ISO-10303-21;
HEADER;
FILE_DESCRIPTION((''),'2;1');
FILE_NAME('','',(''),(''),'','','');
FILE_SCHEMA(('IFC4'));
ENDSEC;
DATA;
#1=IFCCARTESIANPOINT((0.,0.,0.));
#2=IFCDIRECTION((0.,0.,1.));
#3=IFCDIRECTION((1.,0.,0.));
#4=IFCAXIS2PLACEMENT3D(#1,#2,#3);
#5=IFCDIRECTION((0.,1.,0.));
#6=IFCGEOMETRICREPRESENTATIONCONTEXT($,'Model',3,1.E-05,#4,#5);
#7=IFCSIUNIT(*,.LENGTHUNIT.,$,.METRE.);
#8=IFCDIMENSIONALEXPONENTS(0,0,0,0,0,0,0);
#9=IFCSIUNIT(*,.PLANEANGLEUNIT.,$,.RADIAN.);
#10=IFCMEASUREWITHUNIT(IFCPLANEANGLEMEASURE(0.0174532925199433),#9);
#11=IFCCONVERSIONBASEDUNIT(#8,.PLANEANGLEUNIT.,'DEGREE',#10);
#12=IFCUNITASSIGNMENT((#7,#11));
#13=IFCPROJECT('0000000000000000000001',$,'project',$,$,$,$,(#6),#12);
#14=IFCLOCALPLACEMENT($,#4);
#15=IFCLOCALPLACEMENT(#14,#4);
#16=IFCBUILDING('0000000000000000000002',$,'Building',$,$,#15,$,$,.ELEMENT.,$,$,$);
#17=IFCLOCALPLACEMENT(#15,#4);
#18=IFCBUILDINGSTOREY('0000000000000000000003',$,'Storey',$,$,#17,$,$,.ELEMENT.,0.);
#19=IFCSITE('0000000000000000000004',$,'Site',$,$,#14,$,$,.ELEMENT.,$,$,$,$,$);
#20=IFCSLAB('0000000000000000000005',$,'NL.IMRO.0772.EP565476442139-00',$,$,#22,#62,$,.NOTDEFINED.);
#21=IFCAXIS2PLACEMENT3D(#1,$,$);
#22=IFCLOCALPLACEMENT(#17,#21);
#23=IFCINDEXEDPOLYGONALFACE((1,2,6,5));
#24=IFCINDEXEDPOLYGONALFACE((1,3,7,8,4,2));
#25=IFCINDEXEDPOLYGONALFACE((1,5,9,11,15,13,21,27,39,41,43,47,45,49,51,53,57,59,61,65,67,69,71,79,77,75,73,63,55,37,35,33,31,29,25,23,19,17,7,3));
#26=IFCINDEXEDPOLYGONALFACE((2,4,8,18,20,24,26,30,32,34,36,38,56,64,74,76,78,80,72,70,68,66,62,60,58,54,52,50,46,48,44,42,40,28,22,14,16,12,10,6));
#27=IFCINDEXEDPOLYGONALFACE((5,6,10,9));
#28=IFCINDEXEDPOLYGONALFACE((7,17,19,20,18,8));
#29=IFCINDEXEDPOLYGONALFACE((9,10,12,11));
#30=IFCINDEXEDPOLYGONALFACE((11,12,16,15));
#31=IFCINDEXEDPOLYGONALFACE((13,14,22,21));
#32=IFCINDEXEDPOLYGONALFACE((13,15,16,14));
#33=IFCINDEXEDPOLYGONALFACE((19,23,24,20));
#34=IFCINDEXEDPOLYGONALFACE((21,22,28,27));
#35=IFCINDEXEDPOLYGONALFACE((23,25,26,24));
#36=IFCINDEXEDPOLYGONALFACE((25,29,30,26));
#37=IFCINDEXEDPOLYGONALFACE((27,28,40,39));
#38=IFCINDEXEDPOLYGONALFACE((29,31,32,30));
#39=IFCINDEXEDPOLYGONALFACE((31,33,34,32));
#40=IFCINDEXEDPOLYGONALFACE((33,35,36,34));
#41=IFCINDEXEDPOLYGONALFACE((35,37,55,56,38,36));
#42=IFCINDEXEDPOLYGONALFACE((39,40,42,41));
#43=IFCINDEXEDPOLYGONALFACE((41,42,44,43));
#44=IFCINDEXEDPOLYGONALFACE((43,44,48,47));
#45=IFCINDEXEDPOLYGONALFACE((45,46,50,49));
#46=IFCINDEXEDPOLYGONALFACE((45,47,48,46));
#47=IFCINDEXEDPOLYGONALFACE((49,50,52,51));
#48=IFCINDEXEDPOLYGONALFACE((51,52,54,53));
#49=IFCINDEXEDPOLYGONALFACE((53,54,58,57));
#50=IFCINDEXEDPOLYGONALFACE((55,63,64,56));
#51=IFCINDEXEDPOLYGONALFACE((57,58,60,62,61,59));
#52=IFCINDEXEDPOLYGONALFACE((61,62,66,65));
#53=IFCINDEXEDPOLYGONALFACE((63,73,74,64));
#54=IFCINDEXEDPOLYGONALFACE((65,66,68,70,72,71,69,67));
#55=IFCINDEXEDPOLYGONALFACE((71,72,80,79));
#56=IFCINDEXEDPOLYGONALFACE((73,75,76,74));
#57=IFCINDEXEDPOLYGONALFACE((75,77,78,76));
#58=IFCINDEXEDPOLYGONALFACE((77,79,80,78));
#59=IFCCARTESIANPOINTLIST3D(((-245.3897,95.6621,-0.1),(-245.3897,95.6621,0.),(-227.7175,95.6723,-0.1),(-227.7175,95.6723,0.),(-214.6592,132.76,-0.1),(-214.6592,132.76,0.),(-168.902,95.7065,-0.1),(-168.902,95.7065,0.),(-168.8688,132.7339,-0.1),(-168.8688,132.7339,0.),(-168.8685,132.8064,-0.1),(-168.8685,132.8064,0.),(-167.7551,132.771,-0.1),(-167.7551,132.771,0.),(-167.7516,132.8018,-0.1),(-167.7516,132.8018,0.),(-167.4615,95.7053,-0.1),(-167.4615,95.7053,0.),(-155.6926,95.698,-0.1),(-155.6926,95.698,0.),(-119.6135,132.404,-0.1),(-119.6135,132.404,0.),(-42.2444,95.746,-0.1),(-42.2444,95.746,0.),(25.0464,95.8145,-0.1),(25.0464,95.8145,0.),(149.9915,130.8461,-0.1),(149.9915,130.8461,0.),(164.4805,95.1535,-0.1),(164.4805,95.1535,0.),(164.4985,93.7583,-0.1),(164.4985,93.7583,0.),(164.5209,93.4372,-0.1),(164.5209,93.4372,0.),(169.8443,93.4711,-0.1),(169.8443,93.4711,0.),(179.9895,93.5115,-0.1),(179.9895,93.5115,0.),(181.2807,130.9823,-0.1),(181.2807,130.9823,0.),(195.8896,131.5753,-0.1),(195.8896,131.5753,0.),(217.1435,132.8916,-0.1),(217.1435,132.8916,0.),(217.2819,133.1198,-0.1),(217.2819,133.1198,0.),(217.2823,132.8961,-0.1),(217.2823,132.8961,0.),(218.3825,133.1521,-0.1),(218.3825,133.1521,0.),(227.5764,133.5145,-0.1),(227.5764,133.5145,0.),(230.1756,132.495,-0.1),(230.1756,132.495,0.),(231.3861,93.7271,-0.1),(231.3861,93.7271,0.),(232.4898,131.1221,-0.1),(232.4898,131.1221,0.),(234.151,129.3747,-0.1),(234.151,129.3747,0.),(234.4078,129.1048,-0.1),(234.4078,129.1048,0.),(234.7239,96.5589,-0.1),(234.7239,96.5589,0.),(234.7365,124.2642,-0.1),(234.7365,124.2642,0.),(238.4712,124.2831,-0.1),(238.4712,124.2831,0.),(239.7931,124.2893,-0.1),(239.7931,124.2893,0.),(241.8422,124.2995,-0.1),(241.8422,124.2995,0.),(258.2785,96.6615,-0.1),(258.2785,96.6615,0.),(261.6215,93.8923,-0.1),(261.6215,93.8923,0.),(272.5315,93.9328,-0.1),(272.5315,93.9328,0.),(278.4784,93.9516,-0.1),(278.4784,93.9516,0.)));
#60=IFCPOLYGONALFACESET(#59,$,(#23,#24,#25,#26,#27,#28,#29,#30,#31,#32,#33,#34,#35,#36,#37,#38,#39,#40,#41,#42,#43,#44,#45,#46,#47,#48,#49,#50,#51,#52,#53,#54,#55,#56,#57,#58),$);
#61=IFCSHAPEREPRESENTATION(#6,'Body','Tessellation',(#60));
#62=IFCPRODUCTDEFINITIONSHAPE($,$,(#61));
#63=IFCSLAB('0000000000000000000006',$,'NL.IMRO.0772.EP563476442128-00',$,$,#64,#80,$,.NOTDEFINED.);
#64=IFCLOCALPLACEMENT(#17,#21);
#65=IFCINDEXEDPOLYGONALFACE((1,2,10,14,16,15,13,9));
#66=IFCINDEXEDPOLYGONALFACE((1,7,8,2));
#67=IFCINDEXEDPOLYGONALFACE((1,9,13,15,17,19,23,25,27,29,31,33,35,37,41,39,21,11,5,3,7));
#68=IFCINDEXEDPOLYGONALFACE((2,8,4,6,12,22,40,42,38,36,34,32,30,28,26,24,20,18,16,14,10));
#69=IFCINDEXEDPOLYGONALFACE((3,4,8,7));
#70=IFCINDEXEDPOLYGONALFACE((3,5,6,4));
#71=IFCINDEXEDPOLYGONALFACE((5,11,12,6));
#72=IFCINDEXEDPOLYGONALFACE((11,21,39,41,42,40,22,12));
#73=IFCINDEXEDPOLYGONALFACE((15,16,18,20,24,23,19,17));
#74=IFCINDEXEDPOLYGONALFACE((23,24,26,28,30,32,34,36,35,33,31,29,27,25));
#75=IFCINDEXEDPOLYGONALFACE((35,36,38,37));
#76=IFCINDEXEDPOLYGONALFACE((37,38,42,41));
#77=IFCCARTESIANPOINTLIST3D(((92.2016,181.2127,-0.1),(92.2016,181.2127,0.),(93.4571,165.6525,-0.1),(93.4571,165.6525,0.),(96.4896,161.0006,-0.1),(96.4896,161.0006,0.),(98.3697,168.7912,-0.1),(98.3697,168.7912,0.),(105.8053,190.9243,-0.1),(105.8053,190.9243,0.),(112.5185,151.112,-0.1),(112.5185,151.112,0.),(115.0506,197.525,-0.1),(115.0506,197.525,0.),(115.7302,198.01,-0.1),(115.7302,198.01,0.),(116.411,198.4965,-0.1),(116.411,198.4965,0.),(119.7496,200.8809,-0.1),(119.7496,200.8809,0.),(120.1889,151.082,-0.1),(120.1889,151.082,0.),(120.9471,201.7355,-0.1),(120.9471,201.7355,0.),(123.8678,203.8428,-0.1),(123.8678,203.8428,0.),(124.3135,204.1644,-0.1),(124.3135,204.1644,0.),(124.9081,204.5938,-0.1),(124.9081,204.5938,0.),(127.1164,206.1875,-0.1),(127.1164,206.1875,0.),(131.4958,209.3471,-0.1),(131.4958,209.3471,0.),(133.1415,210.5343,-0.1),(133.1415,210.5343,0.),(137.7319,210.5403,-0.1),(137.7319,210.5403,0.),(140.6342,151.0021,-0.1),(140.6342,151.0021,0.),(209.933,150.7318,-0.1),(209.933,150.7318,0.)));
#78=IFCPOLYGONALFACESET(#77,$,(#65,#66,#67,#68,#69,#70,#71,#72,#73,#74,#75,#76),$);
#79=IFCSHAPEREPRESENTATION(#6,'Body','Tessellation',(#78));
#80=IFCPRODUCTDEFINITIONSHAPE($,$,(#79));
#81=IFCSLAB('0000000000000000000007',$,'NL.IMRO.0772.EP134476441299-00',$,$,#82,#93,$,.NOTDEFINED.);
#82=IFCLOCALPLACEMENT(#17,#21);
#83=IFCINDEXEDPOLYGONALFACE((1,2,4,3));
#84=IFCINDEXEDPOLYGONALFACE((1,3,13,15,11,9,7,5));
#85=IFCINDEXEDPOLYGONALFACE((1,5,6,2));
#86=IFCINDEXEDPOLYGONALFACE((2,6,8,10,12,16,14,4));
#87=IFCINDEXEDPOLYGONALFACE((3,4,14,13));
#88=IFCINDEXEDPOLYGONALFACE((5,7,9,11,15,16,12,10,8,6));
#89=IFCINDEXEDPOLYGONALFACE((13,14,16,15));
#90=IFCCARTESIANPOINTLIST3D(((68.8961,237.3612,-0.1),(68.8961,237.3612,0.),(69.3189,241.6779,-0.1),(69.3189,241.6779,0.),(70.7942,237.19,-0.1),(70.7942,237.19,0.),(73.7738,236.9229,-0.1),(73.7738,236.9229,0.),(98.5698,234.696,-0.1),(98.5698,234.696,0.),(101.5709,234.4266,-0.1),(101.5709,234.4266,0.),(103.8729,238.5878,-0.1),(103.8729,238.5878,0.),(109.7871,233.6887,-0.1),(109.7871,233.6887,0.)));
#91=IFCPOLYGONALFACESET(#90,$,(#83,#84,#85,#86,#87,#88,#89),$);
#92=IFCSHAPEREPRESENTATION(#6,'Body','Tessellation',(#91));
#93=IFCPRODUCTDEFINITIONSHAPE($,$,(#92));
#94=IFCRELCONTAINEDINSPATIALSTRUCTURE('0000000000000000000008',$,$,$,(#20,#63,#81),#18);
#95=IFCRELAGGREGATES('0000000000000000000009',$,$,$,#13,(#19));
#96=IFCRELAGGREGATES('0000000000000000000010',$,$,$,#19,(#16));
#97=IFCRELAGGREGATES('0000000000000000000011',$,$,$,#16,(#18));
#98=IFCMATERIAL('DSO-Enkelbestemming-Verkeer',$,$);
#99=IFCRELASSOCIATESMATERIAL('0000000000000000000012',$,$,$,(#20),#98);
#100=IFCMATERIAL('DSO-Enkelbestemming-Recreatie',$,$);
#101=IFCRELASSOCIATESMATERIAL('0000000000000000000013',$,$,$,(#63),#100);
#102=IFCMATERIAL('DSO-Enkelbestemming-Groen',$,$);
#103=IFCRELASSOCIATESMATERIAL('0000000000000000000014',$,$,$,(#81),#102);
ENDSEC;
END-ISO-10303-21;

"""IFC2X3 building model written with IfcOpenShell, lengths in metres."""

from ifc_helpers import new_model, entity, si_unit, converted_unit, direction, frame, origin_with_axes, place, context, project, spatial, polyline, outline, extrude, material, element, save


model = new_model("IFC2X3")

# Units and contexts
model_context = context("Model", 3, precision=1e-05, world=origin_with_axes(), true_north=direction((0.0, 1.0, 0.0)))
ifc_project = project(units=[si_unit("LENGTHUNIT", "METRE"), converted_unit("PLANEANGLEUNIT", "DEGREE", entity("IfcPlaneAngleMeasure", 0.0174532925199433), si_unit("PLANEANGLEUNIT", "RADIAN"), dimensions=[0, 0, 0, 0, 0, 0, 0])], contexts=[model_context])

# Site, building, storey
site_placement = place(None, origin_with_axes())
site = spatial("IfcSite", under=ifc_project, at=site_placement, Name="Site", CompositionType="ELEMENT")
building_placement = place(site_placement, origin_with_axes())
building = spatial("IfcBuilding", under=site, at=building_placement, Name="Building", CompositionType="ELEMENT")
storey_placement = place(building_placement, origin_with_axes())
storey = spatial("IfcBuildingStorey", under=building, at=storey_placement, Name="Storey", CompositionType="ELEMENT", Elevation=0.0)

# Slabs
ifc_material_1 = material(Name="DSO-Enkelbestemming-Verkeer")
ifc_material_2 = material(Name="DSO-Enkelbestemming-Groen")
slab_1_placement = place(storey_placement, frame((0.0, 0.0, -0.1), z_axis=(0.0, 0.0, 1.0), x_axis=(1.0, 0.0, 0.0)))
element("IfcSlab", 1, at=slab_1_placement, inside=storey, material=ifc_material_1, Name="NL.IMRO.0772.EP565476442139-00", PredefinedType="NOTDEFINED", context=model_context, shape_type="SweptSolid", body=[
    extrude(outline(polyline([(-168.8688, 132.7339), (-168.8685, 132.8064), (-167.7516, 132.8018), (-167.7551, 132.771), (-119.6135, 132.404), (149.9915, 130.8461), (181.2807, 130.9823), (195.8896, 131.5753), (217.1435, 132.8916), (217.2823, 132.8961), (217.2819, 133.1198), (218.3825, 133.1521), (227.5764, 133.5145), (230.1756, 132.495), (232.4898, 131.1221), (234.151, 129.3747), (234.4078, 129.1048), (234.7365, 124.2642), (238.4712, 124.2831), (239.7931, 124.2893), (241.8422, 124.2995), (278.4784, 93.9516), (272.5315, 93.9328), (261.6215, 93.8923), (258.2785, 96.6615), (234.7239, 96.5589), (231.3861, 93.7271), (179.9895, 93.5115), (169.8443, 93.4711), (164.5209, 93.4372), (164.4985, 93.7583), (164.4805, 95.1535), (25.0464, 95.8145), (-42.2444, 95.746), (-155.6926, 95.698), (-167.4615, 95.7053), (-168.902, 95.7065), (-227.7175, 95.6723), (-245.3897, 95.6621), (-214.6592, 132.76), (-168.8688, 132.7339)])), origin_with_axes(), (0.0, 0.0, 1.0), 0.1),
])
ifc_material_3 = material(Name="DSO-Enkelbestemming-Recreatie")
slab_2_placement = place(storey_placement, frame((0.0, 0.0, -0.1), z_axis=(0.0, 0.0, 1.0), x_axis=(1.0, 0.0, 0.0)))
element("IfcSlab", 2, at=slab_2_placement, inside=storey, material=ifc_material_3, Name="NL.IMRO.0772.EP563476442128-00", PredefinedType="NOTDEFINED", context=model_context, shape_type="SweptSolid", body=[
    extrude(outline(polyline([(140.6342, 151.0021), (120.1889, 151.082), (112.5185, 151.112), (96.4896, 161.0006), (93.4571, 165.6525), (98.3697, 168.7912), (92.2016, 181.2127), (105.8053, 190.9243), (115.0506, 197.525), (115.7302, 198.01), (116.411, 198.4965), (119.7496, 200.8809), (120.9471, 201.7355), (123.8678, 203.8428), (124.3135, 204.1644), (124.9081, 204.5938), (127.1164, 206.1875), (131.4958, 209.3471), (133.1415, 210.5343), (137.7319, 210.5403), (209.933, 150.7318), (140.6342, 151.0021)])), origin_with_axes(), (0.0, 0.0, 1.0), 0.1),
])
slab_3_placement = place(storey_placement, frame((0.0, 0.0, -0.1), z_axis=(0.0, 0.0, 1.0), x_axis=(1.0, 0.0, 0.0)))
element("IfcSlab", 3, at=slab_3_placement, inside=storey, material=ifc_material_2, Name="NL.IMRO.0772.EP134476441299-00", PredefinedType="NOTDEFINED", context=model_context, shape_type="SweptSolid", body=[
    extrude(outline(polyline([(101.5709, 234.4266), (98.5698, 234.696), (73.7738, 236.9229), (70.7942, 237.19), (68.8961, 237.3612), (69.3189, 241.6779), (103.8729, 238.5878), (109.7871, 233.6887), (101.5709, 234.4266)])), origin_with_axes(), (0.0, 0.0, 1.0), 0.1),
])

save(model, "model.ifc")
